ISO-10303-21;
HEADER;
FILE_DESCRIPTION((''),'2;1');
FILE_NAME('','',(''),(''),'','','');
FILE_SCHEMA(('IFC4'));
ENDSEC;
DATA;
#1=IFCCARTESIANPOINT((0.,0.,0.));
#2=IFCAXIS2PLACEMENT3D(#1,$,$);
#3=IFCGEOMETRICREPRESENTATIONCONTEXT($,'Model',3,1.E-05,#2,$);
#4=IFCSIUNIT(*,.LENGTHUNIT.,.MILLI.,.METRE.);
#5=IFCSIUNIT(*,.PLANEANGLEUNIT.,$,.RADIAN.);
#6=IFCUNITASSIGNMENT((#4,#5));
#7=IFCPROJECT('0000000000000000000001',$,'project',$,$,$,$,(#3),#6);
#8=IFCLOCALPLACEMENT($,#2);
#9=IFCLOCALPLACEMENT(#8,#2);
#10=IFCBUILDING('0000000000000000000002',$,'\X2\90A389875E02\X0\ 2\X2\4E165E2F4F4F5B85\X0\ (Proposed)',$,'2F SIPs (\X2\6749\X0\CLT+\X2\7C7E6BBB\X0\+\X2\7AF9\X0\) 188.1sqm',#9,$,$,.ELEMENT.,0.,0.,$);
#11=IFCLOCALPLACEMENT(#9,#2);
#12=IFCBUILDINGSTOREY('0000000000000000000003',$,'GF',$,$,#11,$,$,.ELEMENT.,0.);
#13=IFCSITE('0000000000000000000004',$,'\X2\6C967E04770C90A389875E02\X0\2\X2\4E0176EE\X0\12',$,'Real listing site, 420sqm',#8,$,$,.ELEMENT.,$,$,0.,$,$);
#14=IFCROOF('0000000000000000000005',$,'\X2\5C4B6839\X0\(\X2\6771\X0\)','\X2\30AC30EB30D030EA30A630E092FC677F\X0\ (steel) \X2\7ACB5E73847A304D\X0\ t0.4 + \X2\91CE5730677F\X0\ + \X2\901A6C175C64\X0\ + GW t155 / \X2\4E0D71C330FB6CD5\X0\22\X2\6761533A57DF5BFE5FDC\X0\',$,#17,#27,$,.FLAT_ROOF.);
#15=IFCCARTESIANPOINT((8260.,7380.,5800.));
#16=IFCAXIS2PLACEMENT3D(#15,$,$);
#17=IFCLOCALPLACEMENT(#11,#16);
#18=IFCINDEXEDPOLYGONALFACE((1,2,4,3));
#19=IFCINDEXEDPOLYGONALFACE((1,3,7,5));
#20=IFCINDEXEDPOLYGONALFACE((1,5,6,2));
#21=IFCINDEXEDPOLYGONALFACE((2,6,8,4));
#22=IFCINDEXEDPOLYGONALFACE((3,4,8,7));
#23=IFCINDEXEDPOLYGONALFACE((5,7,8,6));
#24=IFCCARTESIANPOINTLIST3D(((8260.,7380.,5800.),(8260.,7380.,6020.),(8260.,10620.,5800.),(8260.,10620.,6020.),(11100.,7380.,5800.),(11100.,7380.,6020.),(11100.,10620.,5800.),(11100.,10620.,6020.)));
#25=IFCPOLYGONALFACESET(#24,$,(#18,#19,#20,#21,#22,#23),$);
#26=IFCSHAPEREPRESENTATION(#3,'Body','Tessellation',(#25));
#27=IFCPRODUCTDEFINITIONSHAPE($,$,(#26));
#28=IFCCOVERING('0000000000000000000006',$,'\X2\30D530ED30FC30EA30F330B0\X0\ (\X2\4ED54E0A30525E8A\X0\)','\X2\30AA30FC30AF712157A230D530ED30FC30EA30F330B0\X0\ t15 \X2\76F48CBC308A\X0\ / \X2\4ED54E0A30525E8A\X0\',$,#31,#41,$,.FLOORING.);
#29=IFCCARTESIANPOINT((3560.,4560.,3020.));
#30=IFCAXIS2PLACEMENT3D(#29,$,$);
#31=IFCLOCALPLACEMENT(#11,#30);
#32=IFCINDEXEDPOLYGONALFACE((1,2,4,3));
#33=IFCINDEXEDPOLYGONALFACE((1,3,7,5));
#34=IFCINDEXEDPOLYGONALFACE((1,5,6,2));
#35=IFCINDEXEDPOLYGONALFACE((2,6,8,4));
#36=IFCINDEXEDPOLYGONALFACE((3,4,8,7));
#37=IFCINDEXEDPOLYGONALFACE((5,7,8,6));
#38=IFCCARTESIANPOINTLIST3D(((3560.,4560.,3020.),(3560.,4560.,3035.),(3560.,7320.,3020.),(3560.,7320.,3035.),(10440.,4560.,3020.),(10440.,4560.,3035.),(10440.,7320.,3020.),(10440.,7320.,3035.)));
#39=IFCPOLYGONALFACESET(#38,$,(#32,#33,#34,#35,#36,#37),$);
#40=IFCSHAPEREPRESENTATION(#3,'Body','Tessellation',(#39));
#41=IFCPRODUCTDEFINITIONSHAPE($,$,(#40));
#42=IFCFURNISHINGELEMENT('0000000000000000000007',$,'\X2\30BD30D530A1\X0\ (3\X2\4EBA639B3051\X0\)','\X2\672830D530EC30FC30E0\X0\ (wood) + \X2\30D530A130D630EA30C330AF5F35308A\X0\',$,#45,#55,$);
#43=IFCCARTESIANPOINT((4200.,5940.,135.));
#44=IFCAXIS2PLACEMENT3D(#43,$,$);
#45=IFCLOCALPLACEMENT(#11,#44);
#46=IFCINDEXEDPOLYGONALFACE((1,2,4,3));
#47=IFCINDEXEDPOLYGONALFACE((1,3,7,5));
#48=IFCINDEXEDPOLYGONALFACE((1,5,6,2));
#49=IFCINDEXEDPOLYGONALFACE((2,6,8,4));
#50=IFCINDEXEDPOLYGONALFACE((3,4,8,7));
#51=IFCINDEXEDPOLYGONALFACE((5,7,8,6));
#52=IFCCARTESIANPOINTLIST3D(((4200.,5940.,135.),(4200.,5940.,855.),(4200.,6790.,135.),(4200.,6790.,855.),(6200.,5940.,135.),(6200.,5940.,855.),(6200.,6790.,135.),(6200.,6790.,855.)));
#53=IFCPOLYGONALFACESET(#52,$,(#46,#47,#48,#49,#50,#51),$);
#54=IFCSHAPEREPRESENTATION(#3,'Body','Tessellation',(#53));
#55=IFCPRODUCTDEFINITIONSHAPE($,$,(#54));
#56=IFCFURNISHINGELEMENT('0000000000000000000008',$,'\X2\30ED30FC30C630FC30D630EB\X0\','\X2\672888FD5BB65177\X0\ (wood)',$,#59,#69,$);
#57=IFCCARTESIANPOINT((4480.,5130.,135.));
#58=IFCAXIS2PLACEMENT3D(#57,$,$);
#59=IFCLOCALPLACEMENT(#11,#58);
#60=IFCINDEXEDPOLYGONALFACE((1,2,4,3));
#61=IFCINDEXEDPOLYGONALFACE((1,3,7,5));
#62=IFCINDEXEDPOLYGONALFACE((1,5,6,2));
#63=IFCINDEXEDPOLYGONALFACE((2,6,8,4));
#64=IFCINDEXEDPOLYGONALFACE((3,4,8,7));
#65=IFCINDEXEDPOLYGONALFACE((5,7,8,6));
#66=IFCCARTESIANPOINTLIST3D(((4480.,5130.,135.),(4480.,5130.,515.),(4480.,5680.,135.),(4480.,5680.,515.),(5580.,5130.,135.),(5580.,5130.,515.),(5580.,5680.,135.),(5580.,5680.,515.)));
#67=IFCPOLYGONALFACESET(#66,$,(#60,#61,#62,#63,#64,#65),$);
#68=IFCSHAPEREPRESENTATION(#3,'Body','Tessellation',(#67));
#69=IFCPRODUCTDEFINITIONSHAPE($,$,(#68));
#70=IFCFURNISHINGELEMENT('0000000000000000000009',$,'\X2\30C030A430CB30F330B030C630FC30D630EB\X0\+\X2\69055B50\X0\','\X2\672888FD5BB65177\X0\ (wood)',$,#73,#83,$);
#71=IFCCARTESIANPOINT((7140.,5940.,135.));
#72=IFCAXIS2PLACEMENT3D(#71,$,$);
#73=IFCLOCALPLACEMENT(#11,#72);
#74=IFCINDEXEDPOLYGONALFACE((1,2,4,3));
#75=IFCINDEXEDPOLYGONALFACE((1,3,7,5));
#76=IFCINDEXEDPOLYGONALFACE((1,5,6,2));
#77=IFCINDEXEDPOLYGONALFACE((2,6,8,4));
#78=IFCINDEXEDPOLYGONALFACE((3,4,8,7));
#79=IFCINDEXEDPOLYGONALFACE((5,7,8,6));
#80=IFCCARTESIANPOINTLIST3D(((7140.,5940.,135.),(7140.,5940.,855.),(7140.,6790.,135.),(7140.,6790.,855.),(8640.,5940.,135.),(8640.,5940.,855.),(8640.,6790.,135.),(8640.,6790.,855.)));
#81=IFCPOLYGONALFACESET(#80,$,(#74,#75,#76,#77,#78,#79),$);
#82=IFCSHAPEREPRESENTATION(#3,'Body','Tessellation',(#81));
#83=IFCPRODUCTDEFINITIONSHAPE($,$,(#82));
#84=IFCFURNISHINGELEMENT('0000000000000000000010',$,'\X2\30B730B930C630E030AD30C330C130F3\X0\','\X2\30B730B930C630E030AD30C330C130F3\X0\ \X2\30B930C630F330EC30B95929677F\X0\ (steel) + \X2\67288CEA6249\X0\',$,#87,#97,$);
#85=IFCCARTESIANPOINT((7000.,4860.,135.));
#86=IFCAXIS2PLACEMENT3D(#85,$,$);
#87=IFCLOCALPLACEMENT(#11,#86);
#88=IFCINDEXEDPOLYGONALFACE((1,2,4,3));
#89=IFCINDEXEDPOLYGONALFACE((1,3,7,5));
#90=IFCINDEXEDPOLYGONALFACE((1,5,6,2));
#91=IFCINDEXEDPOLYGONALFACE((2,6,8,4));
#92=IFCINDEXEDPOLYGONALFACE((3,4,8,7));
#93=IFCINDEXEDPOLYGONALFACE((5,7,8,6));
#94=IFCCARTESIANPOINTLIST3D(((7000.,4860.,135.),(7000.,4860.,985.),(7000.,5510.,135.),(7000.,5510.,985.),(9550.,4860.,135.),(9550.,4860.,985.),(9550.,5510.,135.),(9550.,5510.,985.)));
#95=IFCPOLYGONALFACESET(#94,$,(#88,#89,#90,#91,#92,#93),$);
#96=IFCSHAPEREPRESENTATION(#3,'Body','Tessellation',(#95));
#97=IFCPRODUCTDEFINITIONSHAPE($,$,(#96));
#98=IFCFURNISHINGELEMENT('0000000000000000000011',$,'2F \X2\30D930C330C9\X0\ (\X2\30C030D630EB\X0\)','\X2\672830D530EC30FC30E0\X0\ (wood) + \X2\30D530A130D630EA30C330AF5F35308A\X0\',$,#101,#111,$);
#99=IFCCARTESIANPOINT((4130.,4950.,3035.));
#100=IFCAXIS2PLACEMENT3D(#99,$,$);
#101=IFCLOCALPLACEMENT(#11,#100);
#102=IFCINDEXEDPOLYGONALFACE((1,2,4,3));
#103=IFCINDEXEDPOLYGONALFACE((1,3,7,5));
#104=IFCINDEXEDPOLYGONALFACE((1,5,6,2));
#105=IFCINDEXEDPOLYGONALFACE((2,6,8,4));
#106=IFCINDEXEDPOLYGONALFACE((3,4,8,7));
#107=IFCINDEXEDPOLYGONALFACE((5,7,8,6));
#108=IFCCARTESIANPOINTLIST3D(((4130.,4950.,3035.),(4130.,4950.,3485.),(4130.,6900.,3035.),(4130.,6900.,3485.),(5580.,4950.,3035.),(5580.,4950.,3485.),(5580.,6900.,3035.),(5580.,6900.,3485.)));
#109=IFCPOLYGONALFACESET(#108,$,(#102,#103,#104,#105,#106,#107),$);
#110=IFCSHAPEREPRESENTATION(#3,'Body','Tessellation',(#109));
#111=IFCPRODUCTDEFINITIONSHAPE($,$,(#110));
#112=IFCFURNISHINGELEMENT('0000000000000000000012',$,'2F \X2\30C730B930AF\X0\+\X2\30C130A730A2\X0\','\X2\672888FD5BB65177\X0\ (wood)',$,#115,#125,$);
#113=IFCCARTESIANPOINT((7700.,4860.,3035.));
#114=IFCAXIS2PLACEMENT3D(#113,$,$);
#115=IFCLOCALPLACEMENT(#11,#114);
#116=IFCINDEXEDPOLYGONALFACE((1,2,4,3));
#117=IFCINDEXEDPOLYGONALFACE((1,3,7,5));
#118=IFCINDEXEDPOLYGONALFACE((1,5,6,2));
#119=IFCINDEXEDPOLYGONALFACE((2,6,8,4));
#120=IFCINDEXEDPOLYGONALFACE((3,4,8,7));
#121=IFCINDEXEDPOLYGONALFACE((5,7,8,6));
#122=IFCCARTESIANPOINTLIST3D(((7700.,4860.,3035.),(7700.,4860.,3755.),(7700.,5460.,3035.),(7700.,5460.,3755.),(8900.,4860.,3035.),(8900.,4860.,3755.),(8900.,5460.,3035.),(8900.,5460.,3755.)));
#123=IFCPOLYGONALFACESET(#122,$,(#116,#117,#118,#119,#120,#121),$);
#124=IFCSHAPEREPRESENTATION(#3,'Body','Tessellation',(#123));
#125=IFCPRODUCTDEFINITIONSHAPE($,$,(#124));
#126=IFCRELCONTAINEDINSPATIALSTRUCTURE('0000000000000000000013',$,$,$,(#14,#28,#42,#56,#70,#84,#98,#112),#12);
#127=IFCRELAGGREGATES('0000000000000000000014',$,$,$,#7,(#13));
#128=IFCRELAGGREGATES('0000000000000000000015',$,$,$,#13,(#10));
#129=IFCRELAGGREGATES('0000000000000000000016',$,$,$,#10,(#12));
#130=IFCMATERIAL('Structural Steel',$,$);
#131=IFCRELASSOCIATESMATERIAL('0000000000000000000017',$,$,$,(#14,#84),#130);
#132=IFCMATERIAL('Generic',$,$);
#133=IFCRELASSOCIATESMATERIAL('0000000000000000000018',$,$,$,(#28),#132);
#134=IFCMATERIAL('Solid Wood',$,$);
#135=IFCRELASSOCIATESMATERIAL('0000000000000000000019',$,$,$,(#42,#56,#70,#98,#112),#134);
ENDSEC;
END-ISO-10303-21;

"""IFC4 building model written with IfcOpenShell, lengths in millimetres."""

from ifc_helpers import new_model, si_unit, frame, frame_2d, origin, place, context, project, spatial, rectangle, extrude, material, element, save


model = new_model("IFC4")

# Units and contexts
model_context = context("Model", 3, precision=1e-05, world=origin())
ifc_project = project(units=[si_unit("LENGTHUNIT", "METRE", prefix="MILLI"), si_unit("PLANEANGLEUNIT", "RADIAN")], contexts=[model_context])

# Site, building, storey
site_placement = place(None, origin())
site = spatial("IfcSite", under=ifc_project, at=site_placement, Name="沖縄県那覇市2丁目12", ObjectType="Real listing site, 420sqm", CompositionType="ELEMENT", RefElevation=0.0)
building_placement = place(site_placement, origin())
building = spatial("IfcBuilding", under=site, at=building_placement, Name="那覇市 2世帯住宅 (Proposed)", ObjectType="2F SIPs (杉CLT+籾殻+竹) 188.1sqm", CompositionType="ELEMENT", ElevationOfRefHeight=0.0, ElevationOfTerrain=0.0)
storey_placement = place(building_placement, origin())
storey = spatial("IfcBuildingStorey", under=building, at=storey_placement, Name="GF", CompositionType="ELEMENT", Elevation=0.0)

# Shared definitions
ifc_material_1 = material(Name="Solid Wood")

# Shared definitions
ifc_material_2 = material(Name="Generic")

# Roof
ifc_material_3 = material(Name="Structural Steel")
roof_placement = place(storey_placement, frame((8260.0, 7380.0, 5800.0)))
element("IfcRoof", 1, at=roof_placement, inside=storey, material=ifc_material_3, Name="屋根(東)", Description="ガルバリウム鋼板 (steel) 立平葺き t0.4 + 野地板 + 通気層 + GW t155 / 不燃・法22条区域対応", PredefinedType="FLAT_ROOF", context=model_context, shape_type="SweptSolid", body=[
    extrude(rectangle(XDim=2840.0, YDim=3240.0, at=frame_2d((1420.0, 1620.0))), frame((8260.0, 7380.0, 5800.0)), (0.0, 0.0, 1.0), 220.0),
])

# Covering
covering_placement = place(storey_placement, frame((3560.0, 4560.0, 3020.0)))
element("IfcCovering", 2, at=covering_placement, inside=storey, material=ifc_material_2, Name="フローリング (仕上げ床)", Description="オーク無垢フローリング t15 直貼り / 仕上げ床", PredefinedType="FLOORING", context=model_context, shape_type="SweptSolid", body=[
    extrude(rectangle(XDim=6880.0, YDim=2760.0, at=frame_2d((3440.0, 1380.0))), frame((3560.0, 4560.0, 3020.0)), (0.0, 0.0, 1.0), 15.0),
])

# Furnishing elements
furnishing_1_placement = place(storey_placement, frame((4200.0, 5940.0, 135.0)))
element("IfcFurnishingElement", 3, at=furnishing_1_placement, inside=storey, material=ifc_material_1, Name="ソファ (3人掛け)", Description="木フレーム (wood) + ファブリック張り", context=model_context, shape_type="SweptSolid", body=[
    extrude(rectangle(XDim=2000.0, YDim=850.0, at=frame_2d((1000.0, 425.0))), frame((4200.0, 5940.0, 135.0)), (0.0, 0.0, 1.0), 720.0),
])
furnishing_2_placement = place(storey_placement, frame((4480.0, 5130.0, 135.0)))
element("IfcFurnishingElement", 4, at=furnishing_2_placement, inside=storey, material=ifc_material_1, Name="ローテーブル", Description="木製家具 (wood)", context=model_context, shape_type="SweptSolid", body=[
    extrude(rectangle(XDim=1100.0, YDim=550.0, at=frame_2d((550.0, 275.0))), frame((4480.0, 5130.0, 135.0)), (0.0, 0.0, 1.0), 380.0),
])
furnishing_3_placement = place(storey_placement, frame((7140.0, 5940.0, 135.0)))
element("IfcFurnishingElement", 5, at=furnishing_3_placement, inside=storey, material=ifc_material_1, Name="ダイニングテーブル+椅子", Description="木製家具 (wood)", context=model_context, shape_type="SweptSolid", body=[
    extrude(rectangle(XDim=1500.0, YDim=850.0, at=frame_2d((750.0, 425.0))), frame((7140.0, 5940.0, 135.0)), (0.0, 0.0, 1.0), 720.0),
])
furnishing_4_placement = place(storey_placement, frame((7000.0, 4860.0, 135.0)))
element("IfcFurnishingElement", 6, at=furnishing_4_placement, inside=storey, material=ifc_material_3, Name="システムキッチン", Description="システムキッチン ステンレス天板 (steel) + 木質扉", context=model_context, shape_type="SweptSolid", body=[
    extrude(rectangle(XDim=2550.0, YDim=650.0, at=frame_2d((1275.0, 325.0))), frame((7000.0, 4860.0, 135.0)), (0.0, 0.0, 1.0), 850.0),
])
furnishing_5_placement = place(storey_placement, frame((4130.0, 4950.0, 3035.0)))
element("IfcFurnishingElement", 7, at=furnishing_5_placement, inside=storey, material=ifc_material_1, Name="2F ベッド (ダブル)", Description="木フレーム (wood) + ファブリック張り", context=model_context, shape_type="SweptSolid", body=[
    extrude(rectangle(XDim=1450.0, YDim=1950.0, at=frame_2d((725.0, 975.0))), frame((4130.0, 4950.0, 3035.0)), (0.0, 0.0, 1.0), 450.0),
])
furnishing_6_placement = place(storey_placement, frame((7700.0, 4860.0, 3035.0)))
element("IfcFurnishingElement", 8, at=furnishing_6_placement, inside=storey, material=ifc_material_1, Name="2F デスク+チェア", Description="木製家具 (wood)", context=model_context, shape_type="SweptSolid", body=[
    extrude(rectangle(XDim=1200.0, YDim=600.0, at=frame_2d((600.0, 300.0))), frame((7700.0, 4860.0, 3035.0)), (0.0, 0.0, 1.0), 720.0),
])

save(model, "model.ifc")
